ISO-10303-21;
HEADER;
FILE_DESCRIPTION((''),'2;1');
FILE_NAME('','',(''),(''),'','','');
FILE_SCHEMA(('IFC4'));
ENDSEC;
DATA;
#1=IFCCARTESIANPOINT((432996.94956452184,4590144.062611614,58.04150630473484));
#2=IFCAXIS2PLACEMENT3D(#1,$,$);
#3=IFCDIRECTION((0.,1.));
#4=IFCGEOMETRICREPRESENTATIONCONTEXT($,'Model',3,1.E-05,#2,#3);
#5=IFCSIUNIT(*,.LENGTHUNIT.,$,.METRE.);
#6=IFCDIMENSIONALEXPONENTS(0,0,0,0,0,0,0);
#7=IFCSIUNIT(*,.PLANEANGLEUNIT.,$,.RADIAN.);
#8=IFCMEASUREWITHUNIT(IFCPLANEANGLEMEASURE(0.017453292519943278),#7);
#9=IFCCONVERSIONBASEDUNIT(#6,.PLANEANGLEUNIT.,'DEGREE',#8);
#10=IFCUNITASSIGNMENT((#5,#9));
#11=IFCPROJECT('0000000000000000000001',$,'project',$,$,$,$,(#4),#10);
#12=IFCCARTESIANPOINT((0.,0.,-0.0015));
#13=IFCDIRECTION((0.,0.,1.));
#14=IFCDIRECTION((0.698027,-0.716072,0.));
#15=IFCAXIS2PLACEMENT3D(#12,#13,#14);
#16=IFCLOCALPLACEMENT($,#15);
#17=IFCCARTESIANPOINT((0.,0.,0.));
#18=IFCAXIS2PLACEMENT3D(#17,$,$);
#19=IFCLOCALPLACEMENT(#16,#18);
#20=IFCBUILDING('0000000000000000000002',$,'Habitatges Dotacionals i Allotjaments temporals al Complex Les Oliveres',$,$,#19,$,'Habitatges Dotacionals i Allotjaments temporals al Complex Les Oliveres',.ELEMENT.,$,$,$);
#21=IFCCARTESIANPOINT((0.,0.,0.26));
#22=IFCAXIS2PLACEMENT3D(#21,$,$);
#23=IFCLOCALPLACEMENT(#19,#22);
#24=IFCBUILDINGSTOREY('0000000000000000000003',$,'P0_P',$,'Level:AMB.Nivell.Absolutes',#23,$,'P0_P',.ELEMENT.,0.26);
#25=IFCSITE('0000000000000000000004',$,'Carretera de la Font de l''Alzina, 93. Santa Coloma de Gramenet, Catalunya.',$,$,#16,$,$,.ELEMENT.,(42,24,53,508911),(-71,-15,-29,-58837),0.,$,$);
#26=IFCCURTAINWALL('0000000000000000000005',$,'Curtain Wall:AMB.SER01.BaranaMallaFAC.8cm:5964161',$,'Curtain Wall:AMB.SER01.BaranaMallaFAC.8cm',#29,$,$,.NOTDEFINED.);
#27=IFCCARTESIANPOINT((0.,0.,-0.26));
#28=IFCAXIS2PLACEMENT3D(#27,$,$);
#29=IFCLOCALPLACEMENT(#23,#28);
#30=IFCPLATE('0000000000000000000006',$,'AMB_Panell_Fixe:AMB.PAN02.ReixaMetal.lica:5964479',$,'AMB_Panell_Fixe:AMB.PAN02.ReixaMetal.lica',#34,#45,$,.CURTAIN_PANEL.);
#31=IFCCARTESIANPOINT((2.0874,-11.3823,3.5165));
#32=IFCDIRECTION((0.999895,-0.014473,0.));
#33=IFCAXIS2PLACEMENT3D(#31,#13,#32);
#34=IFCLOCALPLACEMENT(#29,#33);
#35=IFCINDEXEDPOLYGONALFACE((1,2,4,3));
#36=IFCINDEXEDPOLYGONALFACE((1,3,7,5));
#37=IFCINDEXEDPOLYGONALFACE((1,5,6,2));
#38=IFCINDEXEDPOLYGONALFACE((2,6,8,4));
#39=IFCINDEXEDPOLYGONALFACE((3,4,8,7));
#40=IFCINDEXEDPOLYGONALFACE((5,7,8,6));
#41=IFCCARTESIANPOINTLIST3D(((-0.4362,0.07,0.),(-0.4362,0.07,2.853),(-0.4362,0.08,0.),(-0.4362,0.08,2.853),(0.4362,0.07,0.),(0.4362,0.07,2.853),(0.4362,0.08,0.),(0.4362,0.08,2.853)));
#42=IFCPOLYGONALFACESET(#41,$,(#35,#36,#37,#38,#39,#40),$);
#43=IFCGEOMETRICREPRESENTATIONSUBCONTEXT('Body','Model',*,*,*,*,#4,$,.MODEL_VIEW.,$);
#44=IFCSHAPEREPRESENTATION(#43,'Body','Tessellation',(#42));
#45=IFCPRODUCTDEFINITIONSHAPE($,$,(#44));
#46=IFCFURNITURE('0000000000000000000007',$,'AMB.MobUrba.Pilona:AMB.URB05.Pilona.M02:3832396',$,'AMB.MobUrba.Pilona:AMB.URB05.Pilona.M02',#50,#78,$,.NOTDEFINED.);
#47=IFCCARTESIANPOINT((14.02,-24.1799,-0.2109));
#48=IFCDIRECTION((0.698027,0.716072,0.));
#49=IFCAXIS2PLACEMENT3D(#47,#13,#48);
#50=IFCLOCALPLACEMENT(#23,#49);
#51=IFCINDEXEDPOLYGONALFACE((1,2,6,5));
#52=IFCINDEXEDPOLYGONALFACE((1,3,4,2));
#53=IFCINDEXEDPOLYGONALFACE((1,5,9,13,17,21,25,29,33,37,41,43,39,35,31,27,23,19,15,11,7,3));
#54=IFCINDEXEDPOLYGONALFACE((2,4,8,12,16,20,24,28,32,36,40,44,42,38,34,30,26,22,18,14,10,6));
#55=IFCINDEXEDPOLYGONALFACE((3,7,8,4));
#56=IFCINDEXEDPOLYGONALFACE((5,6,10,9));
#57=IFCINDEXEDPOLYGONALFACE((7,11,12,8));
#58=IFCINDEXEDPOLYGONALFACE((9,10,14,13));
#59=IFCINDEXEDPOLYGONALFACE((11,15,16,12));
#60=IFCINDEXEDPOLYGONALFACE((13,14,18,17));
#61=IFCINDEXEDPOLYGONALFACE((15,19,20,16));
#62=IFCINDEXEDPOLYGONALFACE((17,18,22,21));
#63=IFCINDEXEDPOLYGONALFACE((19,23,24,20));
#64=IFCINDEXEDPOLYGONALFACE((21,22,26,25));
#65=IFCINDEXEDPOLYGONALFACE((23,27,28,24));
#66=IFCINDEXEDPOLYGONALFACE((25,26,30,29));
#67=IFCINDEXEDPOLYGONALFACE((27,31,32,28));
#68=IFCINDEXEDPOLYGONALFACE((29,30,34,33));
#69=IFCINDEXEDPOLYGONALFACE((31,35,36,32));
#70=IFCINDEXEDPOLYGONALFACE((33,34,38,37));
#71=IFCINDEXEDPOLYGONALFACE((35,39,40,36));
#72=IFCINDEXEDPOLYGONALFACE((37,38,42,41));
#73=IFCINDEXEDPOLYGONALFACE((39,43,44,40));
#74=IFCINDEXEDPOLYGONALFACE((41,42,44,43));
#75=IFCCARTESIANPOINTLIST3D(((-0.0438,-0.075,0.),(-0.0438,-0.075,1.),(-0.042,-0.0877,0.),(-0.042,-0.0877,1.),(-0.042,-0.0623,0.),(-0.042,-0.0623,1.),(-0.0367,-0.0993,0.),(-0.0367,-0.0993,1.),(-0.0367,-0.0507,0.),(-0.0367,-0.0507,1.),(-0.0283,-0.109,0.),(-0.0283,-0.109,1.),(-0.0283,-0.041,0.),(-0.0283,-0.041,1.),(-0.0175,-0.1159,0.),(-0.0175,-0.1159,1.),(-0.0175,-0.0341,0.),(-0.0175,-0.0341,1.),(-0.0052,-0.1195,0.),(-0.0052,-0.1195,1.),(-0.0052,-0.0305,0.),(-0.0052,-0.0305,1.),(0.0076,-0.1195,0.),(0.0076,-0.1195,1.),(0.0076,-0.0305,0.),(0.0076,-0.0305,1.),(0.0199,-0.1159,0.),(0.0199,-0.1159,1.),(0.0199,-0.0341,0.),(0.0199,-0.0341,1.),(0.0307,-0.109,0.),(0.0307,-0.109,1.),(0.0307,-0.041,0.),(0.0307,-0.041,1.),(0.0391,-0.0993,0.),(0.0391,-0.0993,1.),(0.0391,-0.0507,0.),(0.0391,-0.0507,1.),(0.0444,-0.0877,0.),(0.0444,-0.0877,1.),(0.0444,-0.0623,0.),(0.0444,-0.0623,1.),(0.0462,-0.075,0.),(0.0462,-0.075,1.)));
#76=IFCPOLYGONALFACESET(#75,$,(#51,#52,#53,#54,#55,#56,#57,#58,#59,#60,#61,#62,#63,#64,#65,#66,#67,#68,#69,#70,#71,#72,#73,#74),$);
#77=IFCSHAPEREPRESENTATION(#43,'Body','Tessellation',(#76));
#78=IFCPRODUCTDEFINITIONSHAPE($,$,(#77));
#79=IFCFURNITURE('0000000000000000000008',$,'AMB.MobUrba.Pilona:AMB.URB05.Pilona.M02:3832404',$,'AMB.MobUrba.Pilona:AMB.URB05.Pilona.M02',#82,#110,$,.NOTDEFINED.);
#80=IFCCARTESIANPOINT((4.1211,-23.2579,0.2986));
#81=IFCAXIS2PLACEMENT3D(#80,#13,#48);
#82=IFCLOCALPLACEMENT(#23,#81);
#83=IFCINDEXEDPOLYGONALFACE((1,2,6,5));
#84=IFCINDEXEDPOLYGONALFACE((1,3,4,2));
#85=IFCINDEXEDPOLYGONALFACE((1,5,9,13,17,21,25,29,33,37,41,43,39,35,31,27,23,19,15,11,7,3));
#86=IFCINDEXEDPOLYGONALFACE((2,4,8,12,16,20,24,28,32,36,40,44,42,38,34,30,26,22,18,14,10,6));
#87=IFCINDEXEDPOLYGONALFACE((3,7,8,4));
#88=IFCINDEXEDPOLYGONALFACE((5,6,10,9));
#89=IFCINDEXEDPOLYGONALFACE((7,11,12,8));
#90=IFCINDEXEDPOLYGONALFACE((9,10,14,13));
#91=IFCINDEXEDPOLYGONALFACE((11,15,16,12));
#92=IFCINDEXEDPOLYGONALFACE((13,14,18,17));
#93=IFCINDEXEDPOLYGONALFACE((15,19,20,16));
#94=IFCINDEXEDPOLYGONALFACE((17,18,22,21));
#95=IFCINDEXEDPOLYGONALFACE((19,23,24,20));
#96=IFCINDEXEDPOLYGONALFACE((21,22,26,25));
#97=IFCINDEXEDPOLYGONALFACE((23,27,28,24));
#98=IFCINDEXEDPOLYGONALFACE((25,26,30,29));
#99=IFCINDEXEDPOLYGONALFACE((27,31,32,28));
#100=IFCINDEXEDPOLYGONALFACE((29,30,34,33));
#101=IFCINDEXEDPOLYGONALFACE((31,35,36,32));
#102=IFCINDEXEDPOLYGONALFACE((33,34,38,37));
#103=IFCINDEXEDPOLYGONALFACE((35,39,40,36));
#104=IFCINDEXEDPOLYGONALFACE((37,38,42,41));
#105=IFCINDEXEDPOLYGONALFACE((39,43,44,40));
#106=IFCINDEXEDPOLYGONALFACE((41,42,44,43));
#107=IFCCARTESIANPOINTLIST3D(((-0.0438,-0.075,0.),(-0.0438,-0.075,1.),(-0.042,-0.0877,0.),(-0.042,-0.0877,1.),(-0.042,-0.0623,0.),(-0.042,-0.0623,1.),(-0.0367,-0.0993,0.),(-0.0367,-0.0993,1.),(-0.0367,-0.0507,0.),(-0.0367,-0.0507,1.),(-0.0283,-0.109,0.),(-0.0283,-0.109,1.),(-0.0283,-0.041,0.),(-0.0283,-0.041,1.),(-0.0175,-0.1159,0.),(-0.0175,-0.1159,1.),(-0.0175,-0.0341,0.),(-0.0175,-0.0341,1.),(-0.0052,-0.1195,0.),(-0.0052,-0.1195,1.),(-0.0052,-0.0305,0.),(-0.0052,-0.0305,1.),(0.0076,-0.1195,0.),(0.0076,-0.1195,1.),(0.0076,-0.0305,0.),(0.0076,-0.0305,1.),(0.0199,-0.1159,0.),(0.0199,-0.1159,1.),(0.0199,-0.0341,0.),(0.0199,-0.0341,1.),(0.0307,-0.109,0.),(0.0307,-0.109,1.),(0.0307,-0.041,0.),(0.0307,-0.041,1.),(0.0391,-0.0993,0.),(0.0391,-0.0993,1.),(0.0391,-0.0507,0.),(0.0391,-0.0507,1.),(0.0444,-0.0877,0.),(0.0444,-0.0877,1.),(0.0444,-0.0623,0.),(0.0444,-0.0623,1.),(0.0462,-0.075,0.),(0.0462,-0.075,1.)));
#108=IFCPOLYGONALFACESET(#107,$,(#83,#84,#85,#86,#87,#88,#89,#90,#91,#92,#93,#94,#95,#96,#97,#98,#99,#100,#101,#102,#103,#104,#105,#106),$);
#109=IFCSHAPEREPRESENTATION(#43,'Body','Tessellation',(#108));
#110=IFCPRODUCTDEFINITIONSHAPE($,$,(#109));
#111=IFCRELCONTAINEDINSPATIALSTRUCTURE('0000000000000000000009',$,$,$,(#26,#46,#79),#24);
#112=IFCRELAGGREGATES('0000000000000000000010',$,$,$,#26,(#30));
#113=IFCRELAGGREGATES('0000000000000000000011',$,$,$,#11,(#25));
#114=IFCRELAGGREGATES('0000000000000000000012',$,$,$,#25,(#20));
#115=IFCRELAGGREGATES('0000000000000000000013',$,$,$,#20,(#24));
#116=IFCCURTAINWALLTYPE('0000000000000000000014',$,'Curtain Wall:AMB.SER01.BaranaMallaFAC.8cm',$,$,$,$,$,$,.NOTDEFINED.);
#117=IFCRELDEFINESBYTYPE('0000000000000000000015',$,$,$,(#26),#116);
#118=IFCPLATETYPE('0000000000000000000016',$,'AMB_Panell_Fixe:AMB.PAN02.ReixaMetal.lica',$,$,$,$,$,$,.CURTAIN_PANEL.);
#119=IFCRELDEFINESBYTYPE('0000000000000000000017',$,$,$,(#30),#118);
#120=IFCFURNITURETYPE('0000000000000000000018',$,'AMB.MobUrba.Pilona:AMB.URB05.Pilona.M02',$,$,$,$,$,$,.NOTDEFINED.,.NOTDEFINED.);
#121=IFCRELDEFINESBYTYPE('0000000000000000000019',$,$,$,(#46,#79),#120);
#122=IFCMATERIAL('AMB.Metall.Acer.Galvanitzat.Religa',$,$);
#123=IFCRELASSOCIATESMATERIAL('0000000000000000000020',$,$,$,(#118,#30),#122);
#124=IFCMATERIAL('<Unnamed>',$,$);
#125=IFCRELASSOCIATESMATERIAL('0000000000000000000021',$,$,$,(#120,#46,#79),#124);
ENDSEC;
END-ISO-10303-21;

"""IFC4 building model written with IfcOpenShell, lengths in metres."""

from ifc_helpers import new_model, entity, si_unit, converted_unit, direction, frame, origin, place, context, subcontext, project, spatial, arc, indexed_curve, outline, extrude, source, transform, mapped, material, type_object, type_shapes, element, aggregate, save


model = new_model("IFC4")

# Units and contexts
model_context = context("Model", 3, precision=1e-05, world=frame((432996.94956452184, 4590144.062611614, 58.04150630473484)), true_north=direction((0.0, 1.0)))
body_context = subcontext(model_context, "Body", "Model", "MODEL_VIEW")
ifc_project = project(units=[si_unit("LENGTHUNIT", "METRE"), converted_unit("PLANEANGLEUNIT", "DEGREE", entity("IfcPlaneAngleMeasure", 0.017453292519943278), si_unit("PLANEANGLEUNIT", "RADIAN"), dimensions=[0, 0, 0, 0, 0, 0, 0])], contexts=[model_context])

# Site, building, storey
site_placement = place(None, frame((0.0, 0.0, -0.0015), z_axis=(0.0, 0.0, 1.0), x_axis=(0.698027, -0.716072, 0.0)))
site = spatial("IfcSite", under=ifc_project, at=site_placement, Name="Carretera de la Font de l'Alzina, 93. Santa Coloma de Gramenet, Catalunya.", CompositionType="ELEMENT", RefLatitude=(42, 24, 53, 508911), RefLongitude=(-71, -15, -29, -58837), RefElevation=0.0)
building_placement = place(site_placement, origin())
building = spatial("IfcBuilding", under=site, at=building_placement, Name="Habitatges Dotacionals i Allotjaments temporals al Complex Les Oliveres", LongName="Habitatges Dotacionals i Allotjaments temporals al Complex Les Oliveres", CompositionType="ELEMENT")
storey_placement = place(building_placement, frame((0.0, 0.0, 0.26)))
storey = spatial("IfcBuildingStorey", under=building, at=storey_placement, Name="P0_P", ObjectType="Level:AMB.Nivell.Absolutes", LongName="P0_P", CompositionType="ELEMENT", Elevation=0.26)

# Shared definitions
curtain_wall_type_1 = type_object("IfcCurtainWallType", Name="Curtain Wall:AMB.SER01.BaranaMallaFAC.8cm", PredefinedType="NOTDEFINED")

# Curtain wall
curtain_wall_1_placement = place(storey_placement, frame((0.0, 0.0, -0.26)))
curtain_wall_1 = element("IfcCurtainWall", 1, at=curtain_wall_1_placement, inside=storey, type_object=curtain_wall_type_1, Name="Curtain Wall:AMB.SER01.BaranaMallaFAC.8cm:5964161", ObjectType="Curtain Wall:AMB.SER01.BaranaMallaFAC.8cm", PredefinedType="NOTDEFINED")

# Plate
ifc_material_1 = material(Name="AMB.Metall.Acer.Galvanitzat.Religa")
plate_type = type_object("IfcPlateType", Name="AMB_Panell_Fixe:AMB.PAN02.ReixaMetal.lica", PredefinedType="CURTAIN_PANEL", material=ifc_material_1)
shared_shape_1 = source(origin(), body_context, "Body", "SweptSolid", [
    extrude(outline(indexed_curve([(-0.005, -0.4362), (0.005, -0.4362), (0.005, 0.4362), (-0.005, 0.4362), (-0.005, -0.4362)], self_intersect=False)), frame((0.0, 0.075, 0.0), z_axis=(0.0, 0.0, 1.0), x_axis=(0.0, 1.0, 0.0)), (0.0, 0.0, 1.0), 2.853),
])
type_shapes(plate_type, [shared_shape_1])
plate_placement = place(curtain_wall_1_placement, frame((2.0874, -11.3823, 3.5165), z_axis=(0.0, 0.0, 1.0), x_axis=(0.999895, -0.014473, 0.0)))
plate = element("IfcPlate", 2, at=plate_placement, type_object=plate_type, material=ifc_material_1, Name="AMB_Panell_Fixe:AMB.PAN02.ReixaMetal.lica:5964479", ObjectType="AMB_Panell_Fixe:AMB.PAN02.ReixaMetal.lica", PredefinedType="CURTAIN_PANEL", context=body_context, shape_type="MappedRepresentation", body=[
    mapped(shared_shape_1, transform((0.0, 0.0, 0.0), scale=1.0)),
])
aggregate(curtain_wall_1, [plate])

# Furniture
ifc_material_2 = material(Name="<Unnamed>")
furniture_type = type_object("IfcFurnitureType", Name="AMB.MobUrba.Pilona:AMB.URB05.Pilona.M02", AssemblyPlace="NOTDEFINED", PredefinedType="NOTDEFINED", material=ifc_material_2)
shared_shape_2 = source(origin(), body_context, "Body", "SweptSolid", [
    extrude(outline(indexed_curve([(-0.045, 0.0), (0.0, -0.045), (0.045, 0.0), (0.0, 0.045)], segments=[arc(1, 2, 3), arc(3, 4, 1)], self_intersect=False)), frame((0.0012, -0.075, 0.0)), (0.0, 0.0, 1.0), 1.0),
])
type_shapes(furniture_type, [shared_shape_2])
for number, where, z_axis, x_axis, name in (
    (3, (14.02, -24.1799, -0.2109), (0.0, 0.0, 1.0), (0.698027, 0.716072, 0.0), "AMB.MobUrba.Pilona:AMB.URB05.Pilona.M02:3832396"),
    (4, (4.1211, -23.2579, 0.2986), (0.0, 0.0, 1.0), (0.698027, 0.716072, 0.0), "AMB.MobUrba.Pilona:AMB.URB05.Pilona.M02:3832404"),
):
    element("IfcFurniture", number, at=place(storey_placement, frame(where, z_axis=z_axis, x_axis=x_axis)), inside=storey, type_object=furniture_type, material=ifc_material_2, Name=name, ObjectType="AMB.MobUrba.Pilona:AMB.URB05.Pilona.M02", PredefinedType="NOTDEFINED", context=body_context, shape_type="MappedRepresentation", body=[
        mapped(shared_shape_2, transform((0.0, 0.0, 0.0), scale=1.0)),
    ])

save(model, "model.ifc")
